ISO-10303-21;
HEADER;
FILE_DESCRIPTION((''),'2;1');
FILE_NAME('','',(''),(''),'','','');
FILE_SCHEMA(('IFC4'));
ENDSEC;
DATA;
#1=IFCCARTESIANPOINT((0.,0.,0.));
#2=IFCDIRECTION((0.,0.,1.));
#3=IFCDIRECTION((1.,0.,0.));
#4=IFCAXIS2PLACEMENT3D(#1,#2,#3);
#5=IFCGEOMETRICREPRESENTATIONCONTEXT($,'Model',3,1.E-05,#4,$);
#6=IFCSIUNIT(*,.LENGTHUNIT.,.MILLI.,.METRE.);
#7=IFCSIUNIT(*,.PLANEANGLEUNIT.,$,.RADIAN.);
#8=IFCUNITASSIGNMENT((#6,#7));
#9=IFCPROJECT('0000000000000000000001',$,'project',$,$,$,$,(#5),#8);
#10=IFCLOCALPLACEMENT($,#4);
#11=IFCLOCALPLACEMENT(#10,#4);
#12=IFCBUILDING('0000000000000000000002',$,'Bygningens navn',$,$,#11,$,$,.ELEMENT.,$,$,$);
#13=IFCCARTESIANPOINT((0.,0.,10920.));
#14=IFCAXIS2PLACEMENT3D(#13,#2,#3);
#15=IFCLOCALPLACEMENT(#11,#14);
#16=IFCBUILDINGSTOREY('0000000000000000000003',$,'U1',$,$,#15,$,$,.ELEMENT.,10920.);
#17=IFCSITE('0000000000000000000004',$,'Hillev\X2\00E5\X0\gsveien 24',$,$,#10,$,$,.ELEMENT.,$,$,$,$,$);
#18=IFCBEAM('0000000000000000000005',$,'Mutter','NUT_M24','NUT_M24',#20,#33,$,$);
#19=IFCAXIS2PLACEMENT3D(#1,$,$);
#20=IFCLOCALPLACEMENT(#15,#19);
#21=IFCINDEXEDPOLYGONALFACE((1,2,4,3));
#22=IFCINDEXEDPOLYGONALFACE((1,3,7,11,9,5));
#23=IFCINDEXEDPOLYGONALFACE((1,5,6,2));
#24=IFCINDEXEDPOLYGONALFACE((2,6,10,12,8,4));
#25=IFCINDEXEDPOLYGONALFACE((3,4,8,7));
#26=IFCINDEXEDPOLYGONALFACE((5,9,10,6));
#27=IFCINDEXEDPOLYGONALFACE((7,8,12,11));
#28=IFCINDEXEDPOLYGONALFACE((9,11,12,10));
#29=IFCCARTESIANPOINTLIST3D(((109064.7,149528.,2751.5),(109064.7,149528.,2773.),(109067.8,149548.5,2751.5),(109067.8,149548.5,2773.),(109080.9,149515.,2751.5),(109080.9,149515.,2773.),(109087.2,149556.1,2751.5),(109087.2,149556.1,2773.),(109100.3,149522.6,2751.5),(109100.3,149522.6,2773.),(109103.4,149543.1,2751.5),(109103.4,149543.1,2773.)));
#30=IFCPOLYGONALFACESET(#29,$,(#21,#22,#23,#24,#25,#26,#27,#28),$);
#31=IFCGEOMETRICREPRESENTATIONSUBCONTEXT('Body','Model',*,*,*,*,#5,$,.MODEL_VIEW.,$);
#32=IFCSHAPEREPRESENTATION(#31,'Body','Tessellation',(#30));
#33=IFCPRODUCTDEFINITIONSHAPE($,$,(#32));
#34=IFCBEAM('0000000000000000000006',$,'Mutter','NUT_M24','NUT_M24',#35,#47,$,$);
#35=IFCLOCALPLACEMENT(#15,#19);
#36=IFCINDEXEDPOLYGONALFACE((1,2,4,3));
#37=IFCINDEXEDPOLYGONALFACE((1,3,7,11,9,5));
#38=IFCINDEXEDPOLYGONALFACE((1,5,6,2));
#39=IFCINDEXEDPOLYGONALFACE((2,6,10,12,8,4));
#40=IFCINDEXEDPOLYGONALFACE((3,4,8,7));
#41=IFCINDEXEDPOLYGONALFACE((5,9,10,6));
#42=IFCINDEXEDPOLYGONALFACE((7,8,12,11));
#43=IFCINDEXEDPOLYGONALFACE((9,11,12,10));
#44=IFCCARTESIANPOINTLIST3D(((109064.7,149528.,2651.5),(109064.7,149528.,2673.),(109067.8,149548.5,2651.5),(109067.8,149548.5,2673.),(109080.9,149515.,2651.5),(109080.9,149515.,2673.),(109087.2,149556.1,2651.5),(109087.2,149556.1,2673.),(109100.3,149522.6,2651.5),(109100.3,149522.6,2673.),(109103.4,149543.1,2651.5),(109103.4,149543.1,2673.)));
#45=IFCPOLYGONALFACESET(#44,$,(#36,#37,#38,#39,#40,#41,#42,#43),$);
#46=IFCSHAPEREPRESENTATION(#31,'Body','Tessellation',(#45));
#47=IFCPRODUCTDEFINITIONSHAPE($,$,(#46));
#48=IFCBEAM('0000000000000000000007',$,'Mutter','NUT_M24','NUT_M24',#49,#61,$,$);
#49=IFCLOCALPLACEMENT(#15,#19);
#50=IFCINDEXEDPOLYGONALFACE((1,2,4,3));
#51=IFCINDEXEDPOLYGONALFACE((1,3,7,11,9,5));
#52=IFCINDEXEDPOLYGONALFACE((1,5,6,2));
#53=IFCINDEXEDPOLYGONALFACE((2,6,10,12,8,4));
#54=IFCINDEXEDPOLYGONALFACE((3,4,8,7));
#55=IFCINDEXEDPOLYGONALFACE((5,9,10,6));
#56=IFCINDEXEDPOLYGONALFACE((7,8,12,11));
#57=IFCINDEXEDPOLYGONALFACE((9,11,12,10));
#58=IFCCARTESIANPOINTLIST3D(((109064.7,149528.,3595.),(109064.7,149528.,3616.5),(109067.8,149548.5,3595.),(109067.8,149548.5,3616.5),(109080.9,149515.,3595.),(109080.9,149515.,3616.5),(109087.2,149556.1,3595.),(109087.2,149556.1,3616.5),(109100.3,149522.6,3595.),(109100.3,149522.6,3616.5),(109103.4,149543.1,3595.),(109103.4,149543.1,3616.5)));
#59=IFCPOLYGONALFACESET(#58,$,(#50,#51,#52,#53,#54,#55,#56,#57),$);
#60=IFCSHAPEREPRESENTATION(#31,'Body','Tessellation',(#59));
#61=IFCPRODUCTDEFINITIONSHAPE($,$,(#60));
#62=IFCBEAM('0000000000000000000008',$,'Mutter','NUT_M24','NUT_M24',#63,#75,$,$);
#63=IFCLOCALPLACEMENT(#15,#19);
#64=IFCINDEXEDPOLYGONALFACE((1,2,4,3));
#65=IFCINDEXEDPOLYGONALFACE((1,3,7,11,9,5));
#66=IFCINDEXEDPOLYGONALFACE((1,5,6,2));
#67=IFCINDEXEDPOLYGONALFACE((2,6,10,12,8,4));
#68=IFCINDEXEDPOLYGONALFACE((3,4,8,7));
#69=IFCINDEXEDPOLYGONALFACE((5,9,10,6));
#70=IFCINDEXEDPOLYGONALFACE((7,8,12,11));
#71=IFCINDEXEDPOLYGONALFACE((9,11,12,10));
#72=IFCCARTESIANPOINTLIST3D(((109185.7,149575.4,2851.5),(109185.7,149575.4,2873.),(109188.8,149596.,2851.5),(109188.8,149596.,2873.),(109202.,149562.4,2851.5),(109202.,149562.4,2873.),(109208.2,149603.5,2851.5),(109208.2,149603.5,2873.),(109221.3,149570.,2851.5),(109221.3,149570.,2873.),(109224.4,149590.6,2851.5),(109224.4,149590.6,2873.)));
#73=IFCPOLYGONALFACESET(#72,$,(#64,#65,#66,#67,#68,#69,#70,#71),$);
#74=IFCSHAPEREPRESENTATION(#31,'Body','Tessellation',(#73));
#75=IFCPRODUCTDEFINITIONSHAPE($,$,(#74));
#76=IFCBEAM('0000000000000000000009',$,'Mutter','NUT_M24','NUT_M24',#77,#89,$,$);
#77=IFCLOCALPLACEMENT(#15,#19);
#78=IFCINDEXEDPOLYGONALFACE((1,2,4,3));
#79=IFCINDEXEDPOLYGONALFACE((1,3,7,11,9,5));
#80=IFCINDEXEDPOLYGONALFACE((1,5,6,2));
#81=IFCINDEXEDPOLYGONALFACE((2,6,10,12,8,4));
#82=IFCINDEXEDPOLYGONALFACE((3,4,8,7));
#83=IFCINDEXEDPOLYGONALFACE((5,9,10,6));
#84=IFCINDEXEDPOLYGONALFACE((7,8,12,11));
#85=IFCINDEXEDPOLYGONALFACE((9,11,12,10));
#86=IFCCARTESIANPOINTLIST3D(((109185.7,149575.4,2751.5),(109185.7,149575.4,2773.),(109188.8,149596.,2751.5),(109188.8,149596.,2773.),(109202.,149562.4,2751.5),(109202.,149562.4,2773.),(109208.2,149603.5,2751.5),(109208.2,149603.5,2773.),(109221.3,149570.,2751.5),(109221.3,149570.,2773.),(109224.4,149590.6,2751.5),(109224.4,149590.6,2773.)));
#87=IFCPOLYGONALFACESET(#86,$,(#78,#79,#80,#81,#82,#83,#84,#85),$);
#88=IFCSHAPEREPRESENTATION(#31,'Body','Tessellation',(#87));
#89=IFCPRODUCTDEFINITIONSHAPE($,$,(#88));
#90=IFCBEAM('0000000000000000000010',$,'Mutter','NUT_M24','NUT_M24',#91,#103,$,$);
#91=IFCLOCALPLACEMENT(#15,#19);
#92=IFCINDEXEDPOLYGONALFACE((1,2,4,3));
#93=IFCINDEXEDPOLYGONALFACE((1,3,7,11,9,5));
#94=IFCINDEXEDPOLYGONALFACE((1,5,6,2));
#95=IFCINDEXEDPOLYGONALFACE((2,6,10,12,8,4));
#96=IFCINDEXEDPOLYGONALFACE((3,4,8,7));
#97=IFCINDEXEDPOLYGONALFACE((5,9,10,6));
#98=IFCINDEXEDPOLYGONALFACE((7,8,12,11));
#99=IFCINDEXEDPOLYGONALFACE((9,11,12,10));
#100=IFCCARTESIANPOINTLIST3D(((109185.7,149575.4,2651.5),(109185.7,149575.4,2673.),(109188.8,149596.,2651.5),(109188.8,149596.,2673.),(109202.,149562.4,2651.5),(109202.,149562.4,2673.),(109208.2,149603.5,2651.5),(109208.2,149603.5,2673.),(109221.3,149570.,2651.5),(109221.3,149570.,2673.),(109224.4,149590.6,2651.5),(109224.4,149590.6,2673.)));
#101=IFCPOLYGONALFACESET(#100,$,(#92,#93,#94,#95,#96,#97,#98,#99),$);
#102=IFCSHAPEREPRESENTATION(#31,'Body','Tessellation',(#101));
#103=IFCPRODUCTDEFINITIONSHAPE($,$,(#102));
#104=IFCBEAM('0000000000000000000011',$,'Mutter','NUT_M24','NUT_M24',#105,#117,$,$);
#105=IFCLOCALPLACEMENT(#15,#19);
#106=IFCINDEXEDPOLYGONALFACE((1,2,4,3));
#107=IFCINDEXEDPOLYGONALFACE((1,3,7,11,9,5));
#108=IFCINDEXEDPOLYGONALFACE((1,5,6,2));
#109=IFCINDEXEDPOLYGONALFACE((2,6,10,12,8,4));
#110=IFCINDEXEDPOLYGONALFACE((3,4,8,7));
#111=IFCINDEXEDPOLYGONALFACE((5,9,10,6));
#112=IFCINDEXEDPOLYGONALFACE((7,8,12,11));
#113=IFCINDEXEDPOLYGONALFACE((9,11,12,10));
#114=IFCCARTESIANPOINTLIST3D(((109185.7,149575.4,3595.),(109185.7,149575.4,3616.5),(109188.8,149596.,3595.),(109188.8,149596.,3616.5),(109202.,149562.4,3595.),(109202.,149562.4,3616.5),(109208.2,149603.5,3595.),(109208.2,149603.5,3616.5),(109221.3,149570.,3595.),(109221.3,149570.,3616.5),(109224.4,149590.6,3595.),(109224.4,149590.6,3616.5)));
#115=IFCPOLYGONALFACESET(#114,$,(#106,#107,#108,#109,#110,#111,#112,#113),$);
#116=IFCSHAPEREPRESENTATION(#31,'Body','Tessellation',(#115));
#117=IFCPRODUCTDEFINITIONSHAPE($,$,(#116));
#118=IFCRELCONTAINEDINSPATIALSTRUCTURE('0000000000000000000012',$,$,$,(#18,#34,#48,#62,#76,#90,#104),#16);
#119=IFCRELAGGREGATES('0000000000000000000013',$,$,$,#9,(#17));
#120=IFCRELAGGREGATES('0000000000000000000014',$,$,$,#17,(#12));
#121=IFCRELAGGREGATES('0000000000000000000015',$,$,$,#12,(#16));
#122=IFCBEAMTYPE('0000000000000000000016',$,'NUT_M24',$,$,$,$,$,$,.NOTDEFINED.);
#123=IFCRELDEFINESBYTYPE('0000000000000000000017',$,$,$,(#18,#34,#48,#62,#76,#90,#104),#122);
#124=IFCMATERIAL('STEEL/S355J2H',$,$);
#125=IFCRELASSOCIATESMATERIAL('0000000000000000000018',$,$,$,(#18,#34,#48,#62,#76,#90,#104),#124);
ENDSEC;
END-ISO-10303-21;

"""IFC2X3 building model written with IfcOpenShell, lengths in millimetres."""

from ifc_helpers import new_model, si_unit, frame, origin_with_axes, place, context, subcontext, project, spatial, polyline, outline, extrude, material, type_object, element, save


model = new_model("IFC2X3")

# Units and contexts
model_context = context("Model", 3, precision=1e-05, world=origin_with_axes())
body_context = subcontext(model_context, "Body", "Model", "MODEL_VIEW")
ifc_project = project(units=[si_unit("LENGTHUNIT", "METRE", prefix="MILLI"), si_unit("PLANEANGLEUNIT", "RADIAN")], contexts=[model_context])

# Site, building, storey
site_placement = place(None, origin_with_axes())
site = spatial("IfcSite", under=ifc_project, at=site_placement, Name="Hillevågsveien 24", CompositionType="ELEMENT")
building_placement = place(site_placement, origin_with_axes())
building = spatial("IfcBuilding", under=site, at=building_placement, Name="Bygningens navn", CompositionType="ELEMENT")
storey_placement = place(building_placement, frame((0.0, 0.0, 10920.0), z_axis=(0.0, 0.0, 1.0), x_axis=(1.0, 0.0, 0.0)))
storey = spatial("IfcBuildingStorey", under=building, at=storey_placement, Name="U1", CompositionType="ELEMENT", Elevation=10920.0)

# Beams
ifc_material = material(Name="STEEL/S355J2H")
beam_type_1 = type_object("IfcBeamType", Name="NUT_M24", PredefinedType="NOTDEFINED")
for number, where, z_axis, x_axis, name in (
    (1, (109084.0, 149535.6, 2773.0), (-0.364877, 0.931056, 0.0), (0.0, 0.0, -1.0), "Mutter"),
    (2, (109084.0, 149535.6, 2673.0), (-0.364877, 0.931056, 0.0), (0.0, 0.0, -1.0), "Mutter"),
    (3, (109084.0, 149535.6, 3616.5), (-0.364877, 0.931056, 0.0), (0.0, 0.0, -1.0), "Mutter"),
    (4, (109205.1, 149583.0, 2873.0), (-0.364877, 0.931056, 0.0), (0.0, 0.0, -1.0), "Mutter"),
    (5, (109205.1, 149583.0, 2773.0), (-0.364877, 0.931056, 0.0), (0.0, 0.0, -1.0), "Mutter"),
    (6, (109205.1, 149583.0, 2673.0), (-0.364877, 0.931056, 0.0), (0.0, 0.0, -1.0), "Mutter"),
    (7, (109205.1, 149583.0, 3616.5), (-0.364877, 0.931056, 0.0), (0.0, 0.0, -1.0), "Mutter"),
):
    element("IfcBeam", number, at=place(storey_placement, frame(where, z_axis=z_axis, x_axis=x_axis)), inside=storey, type_object=beam_type_1, material=ifc_material, Name=name, Description="NUT_M24", ObjectType="NUT_M24", context=body_context, shape_type="SweptSolid", body=[
        extrude(outline(polyline([(-10.4, 18.0), (10.4, 18.0), (20.8, 0.0), (10.4, -18.0), (-10.4, -18.0), (-20.8, 0.0), (-10.4, 18.0)])), frame((21.5, 0.0, 0.0), z_axis=(-1.0, 0.0, 0.0), x_axis=(0.0, -1.0, 0.0)), (0.0, 0.0, 1.0), 21.5),
    ])

save(model, "model.ifc")
